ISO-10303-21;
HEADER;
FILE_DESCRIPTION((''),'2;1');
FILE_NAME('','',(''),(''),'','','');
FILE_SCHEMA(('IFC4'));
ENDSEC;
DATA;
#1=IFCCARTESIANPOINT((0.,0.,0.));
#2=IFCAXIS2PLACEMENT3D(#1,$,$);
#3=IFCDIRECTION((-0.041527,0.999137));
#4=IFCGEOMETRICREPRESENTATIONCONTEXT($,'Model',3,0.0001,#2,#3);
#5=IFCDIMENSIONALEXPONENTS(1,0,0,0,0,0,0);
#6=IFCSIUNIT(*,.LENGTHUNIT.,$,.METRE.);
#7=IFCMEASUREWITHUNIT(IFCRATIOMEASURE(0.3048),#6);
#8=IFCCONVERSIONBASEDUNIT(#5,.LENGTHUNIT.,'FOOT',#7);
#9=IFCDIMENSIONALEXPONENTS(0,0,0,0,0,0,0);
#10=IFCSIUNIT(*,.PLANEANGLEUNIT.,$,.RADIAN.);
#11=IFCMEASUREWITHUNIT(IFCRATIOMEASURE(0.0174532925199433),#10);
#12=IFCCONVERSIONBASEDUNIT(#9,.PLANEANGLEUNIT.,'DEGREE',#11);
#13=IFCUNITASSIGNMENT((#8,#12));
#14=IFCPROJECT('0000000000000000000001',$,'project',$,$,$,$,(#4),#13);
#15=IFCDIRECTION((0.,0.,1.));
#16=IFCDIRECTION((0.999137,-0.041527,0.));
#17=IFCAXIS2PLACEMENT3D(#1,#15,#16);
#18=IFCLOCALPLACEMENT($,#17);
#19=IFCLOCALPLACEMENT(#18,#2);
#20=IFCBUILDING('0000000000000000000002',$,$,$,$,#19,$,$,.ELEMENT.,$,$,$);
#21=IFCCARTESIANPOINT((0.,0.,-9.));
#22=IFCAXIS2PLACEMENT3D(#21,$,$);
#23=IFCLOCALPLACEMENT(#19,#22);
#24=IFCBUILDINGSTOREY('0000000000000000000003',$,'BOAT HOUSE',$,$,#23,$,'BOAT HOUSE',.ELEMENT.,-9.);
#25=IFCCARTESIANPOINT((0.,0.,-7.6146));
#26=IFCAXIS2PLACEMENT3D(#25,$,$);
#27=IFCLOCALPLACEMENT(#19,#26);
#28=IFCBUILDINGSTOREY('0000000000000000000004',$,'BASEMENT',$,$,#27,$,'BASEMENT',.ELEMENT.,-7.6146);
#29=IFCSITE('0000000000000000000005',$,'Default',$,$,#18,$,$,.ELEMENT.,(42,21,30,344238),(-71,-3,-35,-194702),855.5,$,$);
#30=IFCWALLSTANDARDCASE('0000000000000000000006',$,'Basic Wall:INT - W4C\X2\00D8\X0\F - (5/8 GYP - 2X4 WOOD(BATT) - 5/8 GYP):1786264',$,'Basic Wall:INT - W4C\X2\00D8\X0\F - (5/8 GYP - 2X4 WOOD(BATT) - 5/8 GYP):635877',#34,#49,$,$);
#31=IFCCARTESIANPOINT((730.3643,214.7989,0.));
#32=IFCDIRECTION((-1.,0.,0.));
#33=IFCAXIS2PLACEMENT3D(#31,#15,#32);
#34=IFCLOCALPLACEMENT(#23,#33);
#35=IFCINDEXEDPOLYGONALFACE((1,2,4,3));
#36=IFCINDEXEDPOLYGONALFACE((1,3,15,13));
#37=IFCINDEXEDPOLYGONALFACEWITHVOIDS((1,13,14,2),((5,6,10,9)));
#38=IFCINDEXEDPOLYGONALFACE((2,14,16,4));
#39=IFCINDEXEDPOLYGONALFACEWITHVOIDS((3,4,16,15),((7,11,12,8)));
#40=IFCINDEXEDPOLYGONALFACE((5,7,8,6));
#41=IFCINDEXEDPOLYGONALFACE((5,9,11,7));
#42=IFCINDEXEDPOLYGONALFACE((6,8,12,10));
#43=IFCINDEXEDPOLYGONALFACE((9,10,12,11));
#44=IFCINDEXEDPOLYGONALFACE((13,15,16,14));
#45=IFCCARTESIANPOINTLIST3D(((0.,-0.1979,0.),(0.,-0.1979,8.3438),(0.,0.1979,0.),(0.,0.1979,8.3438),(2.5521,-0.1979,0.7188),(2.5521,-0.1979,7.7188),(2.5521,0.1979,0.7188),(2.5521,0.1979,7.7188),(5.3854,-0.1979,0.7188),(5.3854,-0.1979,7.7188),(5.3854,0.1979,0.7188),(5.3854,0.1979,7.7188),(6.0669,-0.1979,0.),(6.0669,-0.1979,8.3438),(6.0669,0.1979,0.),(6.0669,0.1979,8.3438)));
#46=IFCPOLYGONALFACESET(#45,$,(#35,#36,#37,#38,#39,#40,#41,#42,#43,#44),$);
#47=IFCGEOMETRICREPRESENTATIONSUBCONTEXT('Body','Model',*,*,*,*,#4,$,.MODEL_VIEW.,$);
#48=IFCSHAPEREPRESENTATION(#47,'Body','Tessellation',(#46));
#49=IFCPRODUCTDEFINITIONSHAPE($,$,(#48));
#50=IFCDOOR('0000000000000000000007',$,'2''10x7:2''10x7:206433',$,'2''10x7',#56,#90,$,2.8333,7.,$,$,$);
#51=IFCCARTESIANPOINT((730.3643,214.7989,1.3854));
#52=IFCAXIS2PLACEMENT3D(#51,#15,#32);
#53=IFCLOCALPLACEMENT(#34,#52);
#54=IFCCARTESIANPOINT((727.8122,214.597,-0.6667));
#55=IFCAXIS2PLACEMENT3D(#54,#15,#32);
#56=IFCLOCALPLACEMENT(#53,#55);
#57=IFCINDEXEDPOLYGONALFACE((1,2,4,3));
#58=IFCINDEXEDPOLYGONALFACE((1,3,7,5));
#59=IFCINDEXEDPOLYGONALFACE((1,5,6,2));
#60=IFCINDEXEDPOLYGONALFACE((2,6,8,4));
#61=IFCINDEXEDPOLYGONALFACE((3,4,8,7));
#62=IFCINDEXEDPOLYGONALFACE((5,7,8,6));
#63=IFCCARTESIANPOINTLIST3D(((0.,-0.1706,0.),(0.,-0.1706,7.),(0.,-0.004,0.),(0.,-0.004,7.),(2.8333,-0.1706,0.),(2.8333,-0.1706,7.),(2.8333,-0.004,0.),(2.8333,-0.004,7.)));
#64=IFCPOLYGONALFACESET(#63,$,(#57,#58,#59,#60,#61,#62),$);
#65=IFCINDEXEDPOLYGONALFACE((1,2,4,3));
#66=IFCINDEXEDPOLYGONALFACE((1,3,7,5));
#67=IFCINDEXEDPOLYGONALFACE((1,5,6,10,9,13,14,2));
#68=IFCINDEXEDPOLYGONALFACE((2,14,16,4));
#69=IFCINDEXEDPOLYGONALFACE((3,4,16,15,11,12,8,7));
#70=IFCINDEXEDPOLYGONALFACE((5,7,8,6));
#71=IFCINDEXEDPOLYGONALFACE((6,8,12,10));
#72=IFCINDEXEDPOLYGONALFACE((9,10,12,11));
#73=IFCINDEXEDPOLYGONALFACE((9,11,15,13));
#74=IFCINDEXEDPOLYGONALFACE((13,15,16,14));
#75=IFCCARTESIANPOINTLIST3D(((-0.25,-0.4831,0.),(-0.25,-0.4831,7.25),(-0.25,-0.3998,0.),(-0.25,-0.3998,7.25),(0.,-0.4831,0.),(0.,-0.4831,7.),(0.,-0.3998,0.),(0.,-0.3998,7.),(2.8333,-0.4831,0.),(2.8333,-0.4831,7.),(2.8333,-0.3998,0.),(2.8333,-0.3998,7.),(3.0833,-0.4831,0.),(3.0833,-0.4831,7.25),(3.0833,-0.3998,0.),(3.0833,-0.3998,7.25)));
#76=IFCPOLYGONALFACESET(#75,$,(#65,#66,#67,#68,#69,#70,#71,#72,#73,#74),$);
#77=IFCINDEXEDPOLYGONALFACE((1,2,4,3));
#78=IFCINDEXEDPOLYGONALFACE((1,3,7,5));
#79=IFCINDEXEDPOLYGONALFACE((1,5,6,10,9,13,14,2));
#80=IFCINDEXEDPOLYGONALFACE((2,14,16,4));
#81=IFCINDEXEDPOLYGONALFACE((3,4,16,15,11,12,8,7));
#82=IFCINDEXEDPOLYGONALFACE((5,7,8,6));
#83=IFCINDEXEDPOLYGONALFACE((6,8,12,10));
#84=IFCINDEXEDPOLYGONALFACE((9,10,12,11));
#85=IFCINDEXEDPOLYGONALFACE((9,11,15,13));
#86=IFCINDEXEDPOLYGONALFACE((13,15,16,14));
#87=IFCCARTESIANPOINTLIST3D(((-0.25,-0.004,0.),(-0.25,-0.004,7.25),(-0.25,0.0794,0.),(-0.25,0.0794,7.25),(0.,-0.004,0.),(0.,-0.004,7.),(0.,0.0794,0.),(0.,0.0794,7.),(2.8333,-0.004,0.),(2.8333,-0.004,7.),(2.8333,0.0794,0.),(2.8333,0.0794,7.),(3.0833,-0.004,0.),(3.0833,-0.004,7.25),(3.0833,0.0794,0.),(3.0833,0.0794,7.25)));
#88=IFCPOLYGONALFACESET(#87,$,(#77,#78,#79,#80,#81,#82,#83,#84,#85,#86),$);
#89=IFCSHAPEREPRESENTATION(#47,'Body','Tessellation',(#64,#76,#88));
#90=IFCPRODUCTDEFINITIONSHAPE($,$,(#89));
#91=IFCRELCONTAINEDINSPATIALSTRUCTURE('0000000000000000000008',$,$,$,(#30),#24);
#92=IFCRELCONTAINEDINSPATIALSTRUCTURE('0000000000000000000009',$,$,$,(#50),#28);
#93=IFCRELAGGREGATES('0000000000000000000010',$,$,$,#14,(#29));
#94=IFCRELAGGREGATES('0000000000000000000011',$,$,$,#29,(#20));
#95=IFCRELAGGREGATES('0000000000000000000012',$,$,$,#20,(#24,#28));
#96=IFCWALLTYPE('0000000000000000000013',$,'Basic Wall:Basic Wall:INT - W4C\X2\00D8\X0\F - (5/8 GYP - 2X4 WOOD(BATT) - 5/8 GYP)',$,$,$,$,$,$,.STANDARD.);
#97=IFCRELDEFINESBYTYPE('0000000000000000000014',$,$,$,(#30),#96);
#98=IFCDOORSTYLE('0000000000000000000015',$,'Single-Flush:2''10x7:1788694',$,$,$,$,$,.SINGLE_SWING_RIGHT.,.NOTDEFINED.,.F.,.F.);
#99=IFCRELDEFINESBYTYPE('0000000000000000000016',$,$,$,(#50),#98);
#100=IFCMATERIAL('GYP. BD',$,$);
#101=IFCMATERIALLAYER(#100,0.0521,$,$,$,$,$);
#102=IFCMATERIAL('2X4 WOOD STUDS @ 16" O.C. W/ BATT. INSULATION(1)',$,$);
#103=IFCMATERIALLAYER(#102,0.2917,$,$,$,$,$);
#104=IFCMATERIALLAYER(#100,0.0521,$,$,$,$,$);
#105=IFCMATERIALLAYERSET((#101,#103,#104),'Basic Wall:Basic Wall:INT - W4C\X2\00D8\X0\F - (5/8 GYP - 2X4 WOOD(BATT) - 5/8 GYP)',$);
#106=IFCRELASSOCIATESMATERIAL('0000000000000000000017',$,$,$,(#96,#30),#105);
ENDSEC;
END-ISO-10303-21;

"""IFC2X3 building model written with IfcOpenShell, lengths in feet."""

from ifc_helpers import new_model, entity, si_unit, converted_unit, direction, frame, frame_2d, origin, place, context, subcontext, project, spatial, polyline, rectangle, outline, extrude, source, transform, mapped, material, layer, layer_set, layer_usage, type_object, type_shapes, element, fill, save


model = new_model("IFC2X3")

# Units and contexts
model_context = context("Model", 3, precision=0.0001, world=origin(), true_north=direction((-0.041527, 0.999137)))
body_context = subcontext(model_context, "Body", "Model", "MODEL_VIEW")
ifc_project = project(units=[converted_unit("LENGTHUNIT", "FOOT", entity("IfcRatioMeasure", 0.3048), si_unit("LENGTHUNIT", "METRE"), dimensions=[1, 0, 0, 0, 0, 0, 0]), converted_unit("PLANEANGLEUNIT", "DEGREE", entity("IfcRatioMeasure", 0.0174532925199433), si_unit("PLANEANGLEUNIT", "RADIAN"), dimensions=[0, 0, 0, 0, 0, 0, 0])], contexts=[model_context])

# Site, building, storey
site_placement = place(None, frame((0.0, 0.0, 0.0), z_axis=(0.0, 0.0, 1.0), x_axis=(0.999137, -0.041527, 0.0)))
site = spatial("IfcSite", under=ifc_project, at=site_placement, Name="Default", CompositionType="ELEMENT", RefLatitude=(42, 21, 30, 344238), RefLongitude=(-71, -3, -35, -194702), RefElevation=855.5)
building_placement = place(site_placement, origin())
building = spatial("IfcBuilding", under=site, at=building_placement, CompositionType="ELEMENT")
storey_1_placement = place(building_placement, frame((0.0, 0.0, -9.0)))
storey_1 = spatial("IfcBuildingStorey", under=building, at=storey_1_placement, Name="BOAT HOUSE", LongName="BOAT HOUSE", CompositionType="ELEMENT", Elevation=-9.0)

# Shared definitions
ifc_material_1 = material(Name="GYP. BD")

# Wall, opening
ifc_layer_1 = layer(ifc_material_1, 0.0521)
ifc_material_2 = material(Name="2X4 WOOD STUDS @ 16\" O.C. W/ BATT. INSULATION(1)")
ifc_layer_2 = layer(ifc_material_2, 0.2917)
ifc_layer_3 = layer(ifc_material_1, 0.0521)
ifc_layer_set_1 = layer_set([ifc_layer_1, ifc_layer_2, ifc_layer_3], Name="Basic Wall:Basic Wall:INT - W4CØF - (5/8 GYP - 2X4 WOOD(BATT) - 5/8 GYP)")
ifc_layer_usage_1 = layer_usage(ifc_layer_set_1, "AXIS2", "NEGATIVE", 0.1979)
wall_type_1 = type_object("IfcWallType", Name="Basic Wall:Basic Wall:INT - W4CØF - (5/8 GYP - 2X4 WOOD(BATT) - 5/8 GYP)", PredefinedType="STANDARD", material=ifc_layer_set_1)
wall_1_placement = place(storey_1_placement, frame((730.3643, 214.7989, 0.0), z_axis=(0.0, 0.0, 1.0), x_axis=(-1.0, 0.0, 0.0)))
wall_1 = element("IfcWallStandardCase", 1, at=wall_1_placement, inside=storey_1, type_object=wall_type_1, material=ifc_layer_usage_1, Name="Basic Wall:INT - W4CØF - (5/8 GYP - 2X4 WOOD(BATT) - 5/8 GYP):1786264", ObjectType="Basic Wall:INT - W4CØF - (5/8 GYP - 2X4 WOOD(BATT) - 5/8 GYP):635877", context=body_context, shape_type="SweptSolid", body=[
    extrude(rectangle(XDim=6.0669, YDim=0.3958, at=frame_2d((3.0334, 0.0), x_axis=(-1.0, 0.0))), origin(), (0.0, 0.0, 1.0), 8.3438),
])
opening_1_placement = place(wall_1_placement, frame((730.3643, 214.7989, 1.3854), z_axis=(0.0, 0.0, 1.0), x_axis=(-1.0, 0.0, 0.0)))
opening_1 = element("IfcOpeningElement", 2, at=opening_1_placement, cuts=wall_1, ObjectType="Opening", context=body_context, shape_type="SweptSolid", body=[
    extrude(rectangle(XDim=7.0, YDim=2.8333, at=frame_2d((0.0, 0.0), x_axis=(1.0, 0.0))), frame((726.3956, 215.0008, 2.8333), z_axis=(0.0, -1.0, 0.0), x_axis=(0.0, 0.0, -1.0)), (0.0, 0.0, 1.0), 0.4038),
])

# Shared definitions
storey_2_placement = place(building_placement, frame((0.0, 0.0, -7.6146)))
storey_2 = spatial("IfcBuildingStorey", under=building, at=storey_2_placement, Name="BASEMENT", LongName="BASEMENT", CompositionType="ELEMENT", Elevation=-7.6146)

# Door
door_style = type_object("IfcDoorStyle", Name="Single-Flush:2'10x7:1788694", ConstructionType="NOTDEFINED", OperationType="SINGLE_SWING_RIGHT", ParameterTakesPrecedence=False, Sizeable=False)
shared_shape = source(origin(), body_context, "Body", "SweptSolid", [
    extrude(rectangle(XDim=2.8333, YDim=0.1667, at=frame_2d((0.0, 0.0), x_axis=(1.0, 0.0))), frame((1.4167, -0.0873, 0.0), z_axis=(0.0, 0.0, 1.0), x_axis=(-1.0, 0.0, 0.0)), (0.0, 0.0, 1.0), 7.0),
    extrude(outline(polyline([(-1.6667, -3.5625), (-1.4167, -3.5625), (-1.4167, 3.4375), (1.4167, 3.4375), (1.4167, -3.5625), (1.6667, -3.5625), (1.6667, 3.6875), (-1.6667, 3.6875), (-1.6667, -3.5625)])), frame((1.4167, -0.4831, 3.5625), z_axis=(0.0, 1.0, 0.0), x_axis=(-1.0, 0.0, 0.0)), (0.0, 0.0, 1.0), 0.0833),
    extrude(outline(polyline([(-3.6875, -1.6667), (3.5625, -1.6667), (3.5625, -1.4167), (-3.4375, -1.4167), (-3.4375, 1.4167), (3.5625, 1.4167), (3.5625, 1.6667), (-3.6875, 1.6667), (-3.6875, -1.6667)])), frame((1.4167, -0.004, 3.5625), z_axis=(0.0, 1.0, 0.0), x_axis=(0.0, 0.0, -1.0)), (0.0, 0.0, 1.0), 0.0833),
])
type_shapes(door_style, [shared_shape])
door_placement = place(opening_1_placement, frame((727.8122, 214.597, -0.6667), z_axis=(0.0, 0.0, 1.0), x_axis=(-1.0, 0.0, 0.0)))
door = element("IfcDoor", 3, at=door_placement, inside=storey_2, type_object=door_style, Name="2'10x7:2'10x7:206433", ObjectType="2'10x7", OverallHeight=2.8333, OverallWidth=7.0, context=body_context, shape_type="MappedRepresentation", body=[
    mapped(shared_shape, transform((0.0, 0.0, 0.0), scale=1.0)),
])
fill(opening_1, door)

save(model, "model.ifc")
